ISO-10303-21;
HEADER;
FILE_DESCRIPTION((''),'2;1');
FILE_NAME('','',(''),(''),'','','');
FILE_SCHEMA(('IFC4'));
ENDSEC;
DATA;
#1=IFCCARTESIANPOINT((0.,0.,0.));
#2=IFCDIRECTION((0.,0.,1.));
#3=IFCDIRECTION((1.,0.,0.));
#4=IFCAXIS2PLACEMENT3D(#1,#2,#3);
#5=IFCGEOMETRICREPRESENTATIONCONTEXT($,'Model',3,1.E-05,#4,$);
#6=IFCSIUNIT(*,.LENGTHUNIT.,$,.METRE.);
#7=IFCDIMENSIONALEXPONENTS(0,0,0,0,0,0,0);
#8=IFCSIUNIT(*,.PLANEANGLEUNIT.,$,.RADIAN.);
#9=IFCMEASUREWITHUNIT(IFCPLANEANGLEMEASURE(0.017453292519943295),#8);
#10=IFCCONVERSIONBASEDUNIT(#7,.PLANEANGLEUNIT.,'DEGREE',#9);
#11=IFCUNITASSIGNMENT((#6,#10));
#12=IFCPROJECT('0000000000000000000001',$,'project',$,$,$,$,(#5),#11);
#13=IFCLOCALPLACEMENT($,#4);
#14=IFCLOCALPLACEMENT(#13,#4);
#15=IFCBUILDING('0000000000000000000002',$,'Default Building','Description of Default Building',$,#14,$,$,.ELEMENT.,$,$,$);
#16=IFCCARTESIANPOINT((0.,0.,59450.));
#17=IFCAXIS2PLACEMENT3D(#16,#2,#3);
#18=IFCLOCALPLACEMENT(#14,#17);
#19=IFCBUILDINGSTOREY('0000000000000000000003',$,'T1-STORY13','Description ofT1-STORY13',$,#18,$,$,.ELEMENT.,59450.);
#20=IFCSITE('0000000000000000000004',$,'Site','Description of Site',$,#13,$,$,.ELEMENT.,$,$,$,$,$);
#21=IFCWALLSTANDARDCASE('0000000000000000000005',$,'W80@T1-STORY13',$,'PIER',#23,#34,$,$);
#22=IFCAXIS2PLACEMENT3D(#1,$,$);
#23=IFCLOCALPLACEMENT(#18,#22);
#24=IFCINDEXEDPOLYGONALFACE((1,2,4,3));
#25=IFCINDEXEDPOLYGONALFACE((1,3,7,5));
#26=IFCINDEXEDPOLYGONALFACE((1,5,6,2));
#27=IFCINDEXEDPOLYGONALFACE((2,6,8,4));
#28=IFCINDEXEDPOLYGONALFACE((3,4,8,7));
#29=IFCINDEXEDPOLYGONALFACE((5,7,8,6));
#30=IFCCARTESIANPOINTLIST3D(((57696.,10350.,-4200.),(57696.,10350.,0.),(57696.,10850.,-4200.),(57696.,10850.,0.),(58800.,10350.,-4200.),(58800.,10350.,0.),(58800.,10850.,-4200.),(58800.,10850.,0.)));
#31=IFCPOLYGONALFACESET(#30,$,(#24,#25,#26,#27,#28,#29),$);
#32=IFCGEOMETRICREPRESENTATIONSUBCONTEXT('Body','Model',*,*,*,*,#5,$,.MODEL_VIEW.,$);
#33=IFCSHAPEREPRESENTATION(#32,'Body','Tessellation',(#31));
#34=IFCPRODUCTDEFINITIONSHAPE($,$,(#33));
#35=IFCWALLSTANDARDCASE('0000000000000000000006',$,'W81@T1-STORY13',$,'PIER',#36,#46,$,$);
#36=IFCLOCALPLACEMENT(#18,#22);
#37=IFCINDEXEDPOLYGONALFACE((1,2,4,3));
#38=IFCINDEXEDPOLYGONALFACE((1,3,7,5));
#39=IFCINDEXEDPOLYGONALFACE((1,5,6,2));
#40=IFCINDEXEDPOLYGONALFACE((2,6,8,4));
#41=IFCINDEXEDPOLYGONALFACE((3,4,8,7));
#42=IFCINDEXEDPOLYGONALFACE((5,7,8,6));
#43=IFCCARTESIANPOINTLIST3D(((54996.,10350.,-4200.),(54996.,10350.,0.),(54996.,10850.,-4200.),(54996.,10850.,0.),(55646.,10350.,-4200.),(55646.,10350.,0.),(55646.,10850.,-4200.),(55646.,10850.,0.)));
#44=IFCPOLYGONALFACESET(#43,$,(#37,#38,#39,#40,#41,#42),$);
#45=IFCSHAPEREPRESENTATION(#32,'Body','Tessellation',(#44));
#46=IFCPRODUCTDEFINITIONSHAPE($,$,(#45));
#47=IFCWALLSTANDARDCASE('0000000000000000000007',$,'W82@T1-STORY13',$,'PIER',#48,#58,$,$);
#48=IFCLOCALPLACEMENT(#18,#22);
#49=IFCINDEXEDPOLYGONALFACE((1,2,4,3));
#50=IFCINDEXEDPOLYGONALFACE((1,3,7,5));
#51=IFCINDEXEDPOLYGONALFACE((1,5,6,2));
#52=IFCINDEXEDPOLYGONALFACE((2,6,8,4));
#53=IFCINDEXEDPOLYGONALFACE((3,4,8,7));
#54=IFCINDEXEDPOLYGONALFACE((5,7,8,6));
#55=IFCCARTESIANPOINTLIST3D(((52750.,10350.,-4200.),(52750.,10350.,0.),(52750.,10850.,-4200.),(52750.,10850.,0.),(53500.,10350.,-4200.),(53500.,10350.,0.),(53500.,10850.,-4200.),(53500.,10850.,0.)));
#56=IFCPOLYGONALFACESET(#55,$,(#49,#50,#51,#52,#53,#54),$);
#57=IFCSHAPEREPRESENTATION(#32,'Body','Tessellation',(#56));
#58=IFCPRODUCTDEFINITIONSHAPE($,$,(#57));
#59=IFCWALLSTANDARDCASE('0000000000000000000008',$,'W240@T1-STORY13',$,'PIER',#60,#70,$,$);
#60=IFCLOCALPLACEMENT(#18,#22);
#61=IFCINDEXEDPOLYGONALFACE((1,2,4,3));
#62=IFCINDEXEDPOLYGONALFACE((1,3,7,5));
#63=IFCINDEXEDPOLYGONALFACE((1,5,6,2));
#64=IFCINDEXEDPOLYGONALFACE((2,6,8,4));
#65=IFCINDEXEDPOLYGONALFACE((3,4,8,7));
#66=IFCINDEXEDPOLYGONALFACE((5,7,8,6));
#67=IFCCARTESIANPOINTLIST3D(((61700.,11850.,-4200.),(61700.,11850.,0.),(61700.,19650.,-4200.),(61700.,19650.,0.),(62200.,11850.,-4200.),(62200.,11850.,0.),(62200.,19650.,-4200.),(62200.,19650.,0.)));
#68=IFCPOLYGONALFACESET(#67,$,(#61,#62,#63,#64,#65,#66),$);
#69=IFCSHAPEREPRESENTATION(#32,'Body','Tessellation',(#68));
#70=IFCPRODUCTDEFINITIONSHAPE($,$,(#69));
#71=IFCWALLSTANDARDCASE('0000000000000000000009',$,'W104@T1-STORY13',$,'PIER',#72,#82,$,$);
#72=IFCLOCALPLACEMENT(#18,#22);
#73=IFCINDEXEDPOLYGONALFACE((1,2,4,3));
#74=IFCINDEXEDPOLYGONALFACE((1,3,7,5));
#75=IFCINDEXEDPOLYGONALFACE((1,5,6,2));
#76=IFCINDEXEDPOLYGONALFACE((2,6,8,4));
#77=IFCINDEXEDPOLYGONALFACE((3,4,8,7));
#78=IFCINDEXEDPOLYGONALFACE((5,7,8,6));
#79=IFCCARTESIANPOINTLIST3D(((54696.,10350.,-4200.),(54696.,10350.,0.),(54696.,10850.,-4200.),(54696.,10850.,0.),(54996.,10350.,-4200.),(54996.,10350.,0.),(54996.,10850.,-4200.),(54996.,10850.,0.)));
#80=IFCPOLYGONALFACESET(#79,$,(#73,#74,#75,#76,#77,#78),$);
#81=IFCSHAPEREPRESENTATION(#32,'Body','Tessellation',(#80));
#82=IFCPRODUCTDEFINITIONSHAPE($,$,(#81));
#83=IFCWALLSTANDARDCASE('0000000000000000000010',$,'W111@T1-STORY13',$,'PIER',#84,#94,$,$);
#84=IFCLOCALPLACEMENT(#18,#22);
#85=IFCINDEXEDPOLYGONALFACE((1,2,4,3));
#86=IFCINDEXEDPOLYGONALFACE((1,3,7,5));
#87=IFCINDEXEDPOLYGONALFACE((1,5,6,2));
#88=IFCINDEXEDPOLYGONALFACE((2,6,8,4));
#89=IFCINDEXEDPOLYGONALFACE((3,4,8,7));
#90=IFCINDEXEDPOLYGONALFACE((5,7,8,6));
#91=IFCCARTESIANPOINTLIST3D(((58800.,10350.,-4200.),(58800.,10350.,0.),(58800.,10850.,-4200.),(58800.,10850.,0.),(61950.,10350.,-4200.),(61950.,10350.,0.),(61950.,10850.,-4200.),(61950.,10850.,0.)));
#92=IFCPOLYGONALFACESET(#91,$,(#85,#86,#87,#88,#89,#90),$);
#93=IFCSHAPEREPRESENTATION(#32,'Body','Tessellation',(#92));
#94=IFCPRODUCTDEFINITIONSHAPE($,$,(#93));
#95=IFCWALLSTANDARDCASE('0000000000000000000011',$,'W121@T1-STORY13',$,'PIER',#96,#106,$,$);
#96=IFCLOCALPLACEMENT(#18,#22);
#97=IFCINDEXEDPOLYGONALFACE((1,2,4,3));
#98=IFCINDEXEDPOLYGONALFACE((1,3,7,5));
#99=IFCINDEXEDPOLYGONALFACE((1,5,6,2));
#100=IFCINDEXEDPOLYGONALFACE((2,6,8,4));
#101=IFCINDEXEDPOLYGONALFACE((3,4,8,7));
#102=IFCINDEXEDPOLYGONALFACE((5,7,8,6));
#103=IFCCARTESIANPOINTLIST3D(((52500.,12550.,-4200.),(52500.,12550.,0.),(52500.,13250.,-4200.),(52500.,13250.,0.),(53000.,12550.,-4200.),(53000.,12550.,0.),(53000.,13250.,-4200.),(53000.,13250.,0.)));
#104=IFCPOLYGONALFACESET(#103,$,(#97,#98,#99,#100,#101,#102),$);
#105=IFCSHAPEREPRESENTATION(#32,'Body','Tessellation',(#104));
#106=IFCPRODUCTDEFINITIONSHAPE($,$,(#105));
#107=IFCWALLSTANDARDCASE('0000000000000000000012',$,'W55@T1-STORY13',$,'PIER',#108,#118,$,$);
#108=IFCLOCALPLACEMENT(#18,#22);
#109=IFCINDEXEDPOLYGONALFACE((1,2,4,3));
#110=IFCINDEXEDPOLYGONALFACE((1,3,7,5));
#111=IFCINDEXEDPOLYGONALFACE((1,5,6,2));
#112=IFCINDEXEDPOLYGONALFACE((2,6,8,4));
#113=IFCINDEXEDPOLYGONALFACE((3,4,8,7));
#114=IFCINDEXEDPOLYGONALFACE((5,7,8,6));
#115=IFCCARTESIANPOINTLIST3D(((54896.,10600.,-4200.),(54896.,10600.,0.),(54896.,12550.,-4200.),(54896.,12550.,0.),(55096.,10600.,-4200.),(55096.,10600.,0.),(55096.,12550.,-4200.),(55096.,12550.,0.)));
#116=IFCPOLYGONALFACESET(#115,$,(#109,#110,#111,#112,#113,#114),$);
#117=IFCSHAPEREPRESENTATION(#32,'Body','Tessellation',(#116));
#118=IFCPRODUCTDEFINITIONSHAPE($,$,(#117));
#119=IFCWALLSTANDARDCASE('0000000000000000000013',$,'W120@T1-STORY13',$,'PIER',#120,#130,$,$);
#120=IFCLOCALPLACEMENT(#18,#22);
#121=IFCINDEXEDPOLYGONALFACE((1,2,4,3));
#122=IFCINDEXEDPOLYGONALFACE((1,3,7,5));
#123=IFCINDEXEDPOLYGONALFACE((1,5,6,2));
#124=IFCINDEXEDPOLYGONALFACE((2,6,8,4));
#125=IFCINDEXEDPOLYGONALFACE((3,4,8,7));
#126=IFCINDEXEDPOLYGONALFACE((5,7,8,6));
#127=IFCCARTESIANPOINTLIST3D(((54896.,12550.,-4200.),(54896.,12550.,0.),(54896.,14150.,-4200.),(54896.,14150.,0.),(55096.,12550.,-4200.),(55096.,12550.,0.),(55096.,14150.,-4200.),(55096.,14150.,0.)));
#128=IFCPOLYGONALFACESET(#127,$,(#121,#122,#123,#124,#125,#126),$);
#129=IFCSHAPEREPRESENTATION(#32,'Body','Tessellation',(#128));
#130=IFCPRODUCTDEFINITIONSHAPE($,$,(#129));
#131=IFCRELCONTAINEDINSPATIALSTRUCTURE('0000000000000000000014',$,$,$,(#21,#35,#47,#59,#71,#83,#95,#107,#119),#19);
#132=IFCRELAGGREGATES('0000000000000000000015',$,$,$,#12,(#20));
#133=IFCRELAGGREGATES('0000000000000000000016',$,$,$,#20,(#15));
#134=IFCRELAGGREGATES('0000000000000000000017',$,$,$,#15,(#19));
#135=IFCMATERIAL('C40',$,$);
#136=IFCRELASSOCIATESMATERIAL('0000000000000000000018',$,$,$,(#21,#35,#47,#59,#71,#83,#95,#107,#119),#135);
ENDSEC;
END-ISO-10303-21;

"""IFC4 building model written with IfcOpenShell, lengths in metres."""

from ifc_helpers import new_model, entity, si_unit, converted_unit, frame, origin_with_axes, place, context, subcontext, project, spatial, indexed_curve, outline, extrude, material, element, save


model = new_model("IFC4")

# Units and contexts
model_context = context("Model", 3, precision=1e-05, world=origin_with_axes())
body_context = subcontext(model_context, "Body", "Model", "MODEL_VIEW")
ifc_project = project(units=[si_unit("LENGTHUNIT", "METRE"), converted_unit("PLANEANGLEUNIT", "DEGREE", entity("IfcPlaneAngleMeasure", 0.017453292519943295), si_unit("PLANEANGLEUNIT", "RADIAN"), dimensions=[0, 0, 0, 0, 0, 0, 0])], contexts=[model_context])

# Site, building, storey
site_placement = place(None, origin_with_axes())
site = spatial("IfcSite", under=ifc_project, at=site_placement, Name="Site", Description="Description of Site", CompositionType="ELEMENT")
building_placement = place(site_placement, origin_with_axes())
building = spatial("IfcBuilding", under=site, at=building_placement, Name="Default Building", Description="Description of Default Building", CompositionType="ELEMENT")
storey_placement = place(building_placement, frame((0.0, 0.0, 59450.0), z_axis=(0.0, 0.0, 1.0), x_axis=(1.0, 0.0, 0.0)))
storey = spatial("IfcBuildingStorey", under=building, at=storey_placement, Name="T1-STORY13", Description="Description ofT1-STORY13", CompositionType="ELEMENT", Elevation=59450.0)

# Walls
ifc_material_1 = material(Name="C40")
wall_1_placement = place(storey_placement, frame((57696.0, 10600.0, -4200.0), z_axis=(0.0, 0.0, 1.0), x_axis=(1.0, 0.0, 0.0)))
element("IfcWallStandardCase", 1, at=wall_1_placement, inside=storey, material=ifc_material_1, Name="W80@T1-STORY13", ObjectType="PIER", context=body_context, shape_type="SweptSolid", body=[
    extrude(outline(indexed_curve([(0.0, -250.0), (0.0, 250.0), (1104.0, 250.0), (1104.0, -250.0), (0.0, -250.0)], self_intersect=False)), origin_with_axes(), (0.0, 0.0, 1.0), 4200.0),
])
wall_2_placement = place(storey_placement, frame((54996.0, 10600.0, -4200.0), z_axis=(0.0, 0.0, 1.0), x_axis=(1.0, 0.0, 0.0)))
element("IfcWallStandardCase", 2, at=wall_2_placement, inside=storey, material=ifc_material_1, Name="W81@T1-STORY13", ObjectType="PIER", context=body_context, shape_type="SweptSolid", body=[
    extrude(outline(indexed_curve([(0.0, -250.0), (0.0, 250.0), (650.0, 250.0), (650.0, -250.0), (0.0, -250.0)], self_intersect=False)), origin_with_axes(), (0.0, 0.0, 1.0), 4200.0),
])
wall_3_placement = place(storey_placement, frame((52750.0, 10600.0, -4200.0), z_axis=(0.0, 0.0, 1.0), x_axis=(1.0, 0.0, 0.0)))
element("IfcWallStandardCase", 3, at=wall_3_placement, inside=storey, material=ifc_material_1, Name="W82@T1-STORY13", ObjectType="PIER", context=body_context, shape_type="SweptSolid", body=[
    extrude(outline(indexed_curve([(0.0, -250.0), (0.0, 250.0), (750.0, 250.0), (750.0, -250.0), (0.0, -250.0)], self_intersect=False)), origin_with_axes(), (0.0, 0.0, 1.0), 4200.0),
])
wall_4_placement = place(storey_placement, frame((61950.0, 11850.0, -4200.0), z_axis=(0.0, 0.0, 1.0), x_axis=(0.0, 1.0, 0.0)))
element("IfcWallStandardCase", 4, at=wall_4_placement, inside=storey, material=ifc_material_1, Name="W240@T1-STORY13", ObjectType="PIER", context=body_context, shape_type="SweptSolid", body=[
    extrude(outline(indexed_curve([(0.0, -250.0), (0.0, 250.0), (7800.0, 250.0), (7800.0, -250.0), (0.0, -250.0)], self_intersect=False)), origin_with_axes(), (0.0, 0.0, 1.0), 4200.0),
])
wall_5_placement = place(storey_placement, frame((54696.0, 10600.0, -4200.0), z_axis=(0.0, 0.0, 1.0), x_axis=(1.0, 0.0, 0.0)))
element("IfcWallStandardCase", 5, at=wall_5_placement, inside=storey, material=ifc_material_1, Name="W104@T1-STORY13", ObjectType="PIER", context=body_context, shape_type="SweptSolid", body=[
    extrude(outline(indexed_curve([(0.0, -250.0), (0.0, 250.0), (300.0, 250.0), (300.0, -250.0), (0.0, -250.0)], self_intersect=False)), origin_with_axes(), (0.0, 0.0, 1.0), 4200.0),
])
wall_6_placement = place(storey_placement, frame((58800.0, 10600.0, -4200.0), z_axis=(0.0, 0.0, 1.0), x_axis=(1.0, 0.0, 0.0)))
element("IfcWallStandardCase", 6, at=wall_6_placement, inside=storey, material=ifc_material_1, Name="W111@T1-STORY13", ObjectType="PIER", context=body_context, shape_type="SweptSolid", body=[
    extrude(outline(indexed_curve([(0.0, -250.0), (0.0, 250.0), (3150.0, 250.0), (3150.0, -250.0), (0.0, -250.0)], self_intersect=False)), origin_with_axes(), (0.0, 0.0, 1.0), 4200.0),
])
wall_7_placement = place(storey_placement, frame((52750.0, 12550.0, -4200.0), z_axis=(0.0, 0.0, 1.0), x_axis=(0.0, 1.0, 0.0)))
element("IfcWallStandardCase", 7, at=wall_7_placement, inside=storey, material=ifc_material_1, Name="W121@T1-STORY13", ObjectType="PIER", context=body_context, shape_type="SweptSolid", body=[
    extrude(outline(indexed_curve([(0.0, -250.0), (0.0, 250.0), (700.0, 250.0), (700.0, -250.0), (0.0, -250.0)], self_intersect=False)), origin_with_axes(), (0.0, 0.0, 1.0), 4200.0),
])
wall_8_placement = place(storey_placement, frame((54996.0, 10600.0, -4200.0), z_axis=(0.0, 0.0, 1.0), x_axis=(0.0, 1.0, 0.0)))
element("IfcWallStandardCase", 8, at=wall_8_placement, inside=storey, material=ifc_material_1, Name="W55@T1-STORY13", ObjectType="PIER", context=body_context, shape_type="SweptSolid", body=[
    extrude(outline(indexed_curve([(0.0, -100.0), (0.0, 100.0), (1950.0, 100.0), (1950.0, -100.0), (0.0, -100.0)], self_intersect=False)), origin_with_axes(), (0.0, 0.0, 1.0), 4200.0),
])
wall_9_placement = place(storey_placement, frame((54996.0, 12550.0, -4200.0), z_axis=(0.0, 0.0, 1.0), x_axis=(0.0, 1.0, 0.0)))
element("IfcWallStandardCase", 9, at=wall_9_placement, inside=storey, material=ifc_material_1, Name="W120@T1-STORY13", ObjectType="PIER", context=body_context, shape_type="SweptSolid", body=[
    extrude(outline(indexed_curve([(0.0, -100.0), (0.0, 100.0), (1600.0, 100.0), (1600.0, -100.0), (0.0, -100.0)], self_intersect=False)), origin_with_axes(), (0.0, 0.0, 1.0), 4200.0),
])

save(model, "model.ifc")
